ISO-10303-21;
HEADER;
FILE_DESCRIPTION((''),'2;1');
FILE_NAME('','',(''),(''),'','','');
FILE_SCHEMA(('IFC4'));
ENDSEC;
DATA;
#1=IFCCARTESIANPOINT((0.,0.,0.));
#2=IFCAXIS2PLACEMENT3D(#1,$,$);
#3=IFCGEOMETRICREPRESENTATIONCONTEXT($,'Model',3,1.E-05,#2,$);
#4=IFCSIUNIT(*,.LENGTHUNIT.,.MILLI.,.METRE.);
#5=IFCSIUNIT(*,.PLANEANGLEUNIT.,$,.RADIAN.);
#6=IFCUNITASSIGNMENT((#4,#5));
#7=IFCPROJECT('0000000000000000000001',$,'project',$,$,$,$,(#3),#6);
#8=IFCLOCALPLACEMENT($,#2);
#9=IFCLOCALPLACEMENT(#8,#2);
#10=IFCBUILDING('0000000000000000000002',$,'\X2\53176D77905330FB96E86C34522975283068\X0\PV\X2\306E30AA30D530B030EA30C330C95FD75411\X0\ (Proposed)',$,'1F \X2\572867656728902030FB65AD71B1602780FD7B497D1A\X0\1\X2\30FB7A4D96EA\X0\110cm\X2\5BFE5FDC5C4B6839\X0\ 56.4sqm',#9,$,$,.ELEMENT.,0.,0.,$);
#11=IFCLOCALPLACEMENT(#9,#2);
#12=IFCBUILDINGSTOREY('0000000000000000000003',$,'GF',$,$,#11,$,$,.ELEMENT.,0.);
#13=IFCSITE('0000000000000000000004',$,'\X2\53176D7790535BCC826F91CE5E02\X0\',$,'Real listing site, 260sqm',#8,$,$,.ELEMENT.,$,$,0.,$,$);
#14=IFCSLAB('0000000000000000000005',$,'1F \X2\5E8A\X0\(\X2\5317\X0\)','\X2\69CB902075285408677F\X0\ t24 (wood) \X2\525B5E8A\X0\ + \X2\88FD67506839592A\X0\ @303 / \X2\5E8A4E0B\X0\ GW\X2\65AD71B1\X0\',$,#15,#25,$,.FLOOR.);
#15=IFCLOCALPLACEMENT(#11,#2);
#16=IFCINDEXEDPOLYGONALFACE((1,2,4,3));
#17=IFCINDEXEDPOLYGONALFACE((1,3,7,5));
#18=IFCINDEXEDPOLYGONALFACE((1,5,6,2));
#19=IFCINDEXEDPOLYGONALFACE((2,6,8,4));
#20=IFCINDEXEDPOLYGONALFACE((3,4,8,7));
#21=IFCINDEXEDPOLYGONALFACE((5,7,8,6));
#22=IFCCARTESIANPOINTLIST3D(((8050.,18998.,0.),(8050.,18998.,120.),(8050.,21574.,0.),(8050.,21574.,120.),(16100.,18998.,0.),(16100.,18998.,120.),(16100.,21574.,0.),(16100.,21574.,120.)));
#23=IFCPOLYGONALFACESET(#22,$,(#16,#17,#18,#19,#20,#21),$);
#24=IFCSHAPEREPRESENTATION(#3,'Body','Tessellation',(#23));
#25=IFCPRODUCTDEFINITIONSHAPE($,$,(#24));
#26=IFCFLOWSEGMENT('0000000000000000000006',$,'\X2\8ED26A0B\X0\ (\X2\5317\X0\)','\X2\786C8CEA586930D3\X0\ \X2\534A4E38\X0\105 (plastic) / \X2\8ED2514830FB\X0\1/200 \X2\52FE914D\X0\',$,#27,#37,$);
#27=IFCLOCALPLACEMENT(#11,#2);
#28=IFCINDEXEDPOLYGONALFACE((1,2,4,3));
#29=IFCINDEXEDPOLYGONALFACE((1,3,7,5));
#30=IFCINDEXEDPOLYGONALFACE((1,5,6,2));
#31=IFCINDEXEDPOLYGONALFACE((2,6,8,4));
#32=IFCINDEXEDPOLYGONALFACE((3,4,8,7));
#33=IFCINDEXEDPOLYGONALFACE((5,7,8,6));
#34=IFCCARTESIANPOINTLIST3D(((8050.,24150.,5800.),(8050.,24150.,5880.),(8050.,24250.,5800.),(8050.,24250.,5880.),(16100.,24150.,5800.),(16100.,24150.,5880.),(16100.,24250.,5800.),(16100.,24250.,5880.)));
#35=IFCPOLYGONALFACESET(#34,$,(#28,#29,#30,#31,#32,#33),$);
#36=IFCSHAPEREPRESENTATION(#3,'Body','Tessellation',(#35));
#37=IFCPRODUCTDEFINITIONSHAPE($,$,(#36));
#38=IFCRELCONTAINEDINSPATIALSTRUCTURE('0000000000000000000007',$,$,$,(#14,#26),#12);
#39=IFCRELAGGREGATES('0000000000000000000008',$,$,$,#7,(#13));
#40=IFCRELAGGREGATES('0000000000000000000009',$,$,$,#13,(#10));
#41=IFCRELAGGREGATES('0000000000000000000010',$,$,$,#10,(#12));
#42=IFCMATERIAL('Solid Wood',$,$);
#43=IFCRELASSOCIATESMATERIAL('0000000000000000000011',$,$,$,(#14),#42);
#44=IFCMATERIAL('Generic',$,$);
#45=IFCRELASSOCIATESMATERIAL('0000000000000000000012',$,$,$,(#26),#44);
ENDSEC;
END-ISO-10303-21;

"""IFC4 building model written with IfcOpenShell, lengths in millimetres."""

from ifc_helpers import new_model, si_unit, frame, frame_2d, origin, place, context, project, spatial, rectangle, extrude, material, element, save


model = new_model("IFC4")

# Units and contexts
model_context = context("Model", 3, precision=1e-05, world=origin())
ifc_project = project(units=[si_unit("LENGTHUNIT", "METRE", prefix="MILLI"), si_unit("PLANEANGLEUNIT", "RADIAN")], contexts=[model_context])

# Site, building, storey
site_placement = place(None, origin())
site = spatial("IfcSite", under=ifc_project, at=site_placement, Name="北海道富良野市", ObjectType="Real listing site, 260sqm", CompositionType="ELEMENT", RefElevation=0.0)
building_placement = place(site_placement, origin())
building = spatial("IfcBuilding", under=site, at=building_placement, Name="北海道・雨水利用とPVのオフグリッド志向 (Proposed)", ObjectType="1F 在来木造・断熱性能等級1・積雪110cm対応屋根 56.4sqm", CompositionType="ELEMENT", ElevationOfRefHeight=0.0, ElevationOfTerrain=0.0)
storey_placement = place(building_placement, origin())
storey = spatial("IfcBuildingStorey", under=building, at=storey_placement, Name="GF", CompositionType="ELEMENT", Elevation=0.0)

# Shared definitions
ifc_material_1 = material(Name="Solid Wood")

# Slab
slab_1_placement = place(storey_placement, frame((4025.0, 9499.0, 0.0)))
element("IfcSlab", 1, at=slab_1_placement, inside=storey, material=ifc_material_1, Name="1F 床(北)", Description="構造用合板 t24 (wood) 剛床 + 製材根太 @303 / 床下 GW断熱", PredefinedType="FLOOR", context=model_context, shape_type="SweptSolid", body=[
    extrude(rectangle(XDim=8050.0, YDim=2576.0, at=frame_2d((4025.0, 1288.0))), frame((4025.0, 9499.0, 0.0)), (0.0, 0.0, 1.0), 120.0),
])

# Shared definitions
ifc_material_2 = material(Name="Generic")

# Flow segment
flow_segment_1_placement = place(storey_placement, frame((4025.0, 12075.0, 2900.0)))
element("IfcFlowSegment", 2, at=flow_segment_1_placement, inside=storey, material=ifc_material_2, Name="軒樋 (北)", Description="硬質塩ビ 半丸105 (plastic) / 軒先・1/200 勾配", context=model_context, shape_type="SweptSolid", body=[
    extrude(rectangle(XDim=8050.0, YDim=100.0, at=frame_2d((4025.0, 50.0))), frame((4025.0, 12075.0, 2900.0)), (0.0, 0.0, 1.0), 80.0),
])

save(model, "model.ifc")
